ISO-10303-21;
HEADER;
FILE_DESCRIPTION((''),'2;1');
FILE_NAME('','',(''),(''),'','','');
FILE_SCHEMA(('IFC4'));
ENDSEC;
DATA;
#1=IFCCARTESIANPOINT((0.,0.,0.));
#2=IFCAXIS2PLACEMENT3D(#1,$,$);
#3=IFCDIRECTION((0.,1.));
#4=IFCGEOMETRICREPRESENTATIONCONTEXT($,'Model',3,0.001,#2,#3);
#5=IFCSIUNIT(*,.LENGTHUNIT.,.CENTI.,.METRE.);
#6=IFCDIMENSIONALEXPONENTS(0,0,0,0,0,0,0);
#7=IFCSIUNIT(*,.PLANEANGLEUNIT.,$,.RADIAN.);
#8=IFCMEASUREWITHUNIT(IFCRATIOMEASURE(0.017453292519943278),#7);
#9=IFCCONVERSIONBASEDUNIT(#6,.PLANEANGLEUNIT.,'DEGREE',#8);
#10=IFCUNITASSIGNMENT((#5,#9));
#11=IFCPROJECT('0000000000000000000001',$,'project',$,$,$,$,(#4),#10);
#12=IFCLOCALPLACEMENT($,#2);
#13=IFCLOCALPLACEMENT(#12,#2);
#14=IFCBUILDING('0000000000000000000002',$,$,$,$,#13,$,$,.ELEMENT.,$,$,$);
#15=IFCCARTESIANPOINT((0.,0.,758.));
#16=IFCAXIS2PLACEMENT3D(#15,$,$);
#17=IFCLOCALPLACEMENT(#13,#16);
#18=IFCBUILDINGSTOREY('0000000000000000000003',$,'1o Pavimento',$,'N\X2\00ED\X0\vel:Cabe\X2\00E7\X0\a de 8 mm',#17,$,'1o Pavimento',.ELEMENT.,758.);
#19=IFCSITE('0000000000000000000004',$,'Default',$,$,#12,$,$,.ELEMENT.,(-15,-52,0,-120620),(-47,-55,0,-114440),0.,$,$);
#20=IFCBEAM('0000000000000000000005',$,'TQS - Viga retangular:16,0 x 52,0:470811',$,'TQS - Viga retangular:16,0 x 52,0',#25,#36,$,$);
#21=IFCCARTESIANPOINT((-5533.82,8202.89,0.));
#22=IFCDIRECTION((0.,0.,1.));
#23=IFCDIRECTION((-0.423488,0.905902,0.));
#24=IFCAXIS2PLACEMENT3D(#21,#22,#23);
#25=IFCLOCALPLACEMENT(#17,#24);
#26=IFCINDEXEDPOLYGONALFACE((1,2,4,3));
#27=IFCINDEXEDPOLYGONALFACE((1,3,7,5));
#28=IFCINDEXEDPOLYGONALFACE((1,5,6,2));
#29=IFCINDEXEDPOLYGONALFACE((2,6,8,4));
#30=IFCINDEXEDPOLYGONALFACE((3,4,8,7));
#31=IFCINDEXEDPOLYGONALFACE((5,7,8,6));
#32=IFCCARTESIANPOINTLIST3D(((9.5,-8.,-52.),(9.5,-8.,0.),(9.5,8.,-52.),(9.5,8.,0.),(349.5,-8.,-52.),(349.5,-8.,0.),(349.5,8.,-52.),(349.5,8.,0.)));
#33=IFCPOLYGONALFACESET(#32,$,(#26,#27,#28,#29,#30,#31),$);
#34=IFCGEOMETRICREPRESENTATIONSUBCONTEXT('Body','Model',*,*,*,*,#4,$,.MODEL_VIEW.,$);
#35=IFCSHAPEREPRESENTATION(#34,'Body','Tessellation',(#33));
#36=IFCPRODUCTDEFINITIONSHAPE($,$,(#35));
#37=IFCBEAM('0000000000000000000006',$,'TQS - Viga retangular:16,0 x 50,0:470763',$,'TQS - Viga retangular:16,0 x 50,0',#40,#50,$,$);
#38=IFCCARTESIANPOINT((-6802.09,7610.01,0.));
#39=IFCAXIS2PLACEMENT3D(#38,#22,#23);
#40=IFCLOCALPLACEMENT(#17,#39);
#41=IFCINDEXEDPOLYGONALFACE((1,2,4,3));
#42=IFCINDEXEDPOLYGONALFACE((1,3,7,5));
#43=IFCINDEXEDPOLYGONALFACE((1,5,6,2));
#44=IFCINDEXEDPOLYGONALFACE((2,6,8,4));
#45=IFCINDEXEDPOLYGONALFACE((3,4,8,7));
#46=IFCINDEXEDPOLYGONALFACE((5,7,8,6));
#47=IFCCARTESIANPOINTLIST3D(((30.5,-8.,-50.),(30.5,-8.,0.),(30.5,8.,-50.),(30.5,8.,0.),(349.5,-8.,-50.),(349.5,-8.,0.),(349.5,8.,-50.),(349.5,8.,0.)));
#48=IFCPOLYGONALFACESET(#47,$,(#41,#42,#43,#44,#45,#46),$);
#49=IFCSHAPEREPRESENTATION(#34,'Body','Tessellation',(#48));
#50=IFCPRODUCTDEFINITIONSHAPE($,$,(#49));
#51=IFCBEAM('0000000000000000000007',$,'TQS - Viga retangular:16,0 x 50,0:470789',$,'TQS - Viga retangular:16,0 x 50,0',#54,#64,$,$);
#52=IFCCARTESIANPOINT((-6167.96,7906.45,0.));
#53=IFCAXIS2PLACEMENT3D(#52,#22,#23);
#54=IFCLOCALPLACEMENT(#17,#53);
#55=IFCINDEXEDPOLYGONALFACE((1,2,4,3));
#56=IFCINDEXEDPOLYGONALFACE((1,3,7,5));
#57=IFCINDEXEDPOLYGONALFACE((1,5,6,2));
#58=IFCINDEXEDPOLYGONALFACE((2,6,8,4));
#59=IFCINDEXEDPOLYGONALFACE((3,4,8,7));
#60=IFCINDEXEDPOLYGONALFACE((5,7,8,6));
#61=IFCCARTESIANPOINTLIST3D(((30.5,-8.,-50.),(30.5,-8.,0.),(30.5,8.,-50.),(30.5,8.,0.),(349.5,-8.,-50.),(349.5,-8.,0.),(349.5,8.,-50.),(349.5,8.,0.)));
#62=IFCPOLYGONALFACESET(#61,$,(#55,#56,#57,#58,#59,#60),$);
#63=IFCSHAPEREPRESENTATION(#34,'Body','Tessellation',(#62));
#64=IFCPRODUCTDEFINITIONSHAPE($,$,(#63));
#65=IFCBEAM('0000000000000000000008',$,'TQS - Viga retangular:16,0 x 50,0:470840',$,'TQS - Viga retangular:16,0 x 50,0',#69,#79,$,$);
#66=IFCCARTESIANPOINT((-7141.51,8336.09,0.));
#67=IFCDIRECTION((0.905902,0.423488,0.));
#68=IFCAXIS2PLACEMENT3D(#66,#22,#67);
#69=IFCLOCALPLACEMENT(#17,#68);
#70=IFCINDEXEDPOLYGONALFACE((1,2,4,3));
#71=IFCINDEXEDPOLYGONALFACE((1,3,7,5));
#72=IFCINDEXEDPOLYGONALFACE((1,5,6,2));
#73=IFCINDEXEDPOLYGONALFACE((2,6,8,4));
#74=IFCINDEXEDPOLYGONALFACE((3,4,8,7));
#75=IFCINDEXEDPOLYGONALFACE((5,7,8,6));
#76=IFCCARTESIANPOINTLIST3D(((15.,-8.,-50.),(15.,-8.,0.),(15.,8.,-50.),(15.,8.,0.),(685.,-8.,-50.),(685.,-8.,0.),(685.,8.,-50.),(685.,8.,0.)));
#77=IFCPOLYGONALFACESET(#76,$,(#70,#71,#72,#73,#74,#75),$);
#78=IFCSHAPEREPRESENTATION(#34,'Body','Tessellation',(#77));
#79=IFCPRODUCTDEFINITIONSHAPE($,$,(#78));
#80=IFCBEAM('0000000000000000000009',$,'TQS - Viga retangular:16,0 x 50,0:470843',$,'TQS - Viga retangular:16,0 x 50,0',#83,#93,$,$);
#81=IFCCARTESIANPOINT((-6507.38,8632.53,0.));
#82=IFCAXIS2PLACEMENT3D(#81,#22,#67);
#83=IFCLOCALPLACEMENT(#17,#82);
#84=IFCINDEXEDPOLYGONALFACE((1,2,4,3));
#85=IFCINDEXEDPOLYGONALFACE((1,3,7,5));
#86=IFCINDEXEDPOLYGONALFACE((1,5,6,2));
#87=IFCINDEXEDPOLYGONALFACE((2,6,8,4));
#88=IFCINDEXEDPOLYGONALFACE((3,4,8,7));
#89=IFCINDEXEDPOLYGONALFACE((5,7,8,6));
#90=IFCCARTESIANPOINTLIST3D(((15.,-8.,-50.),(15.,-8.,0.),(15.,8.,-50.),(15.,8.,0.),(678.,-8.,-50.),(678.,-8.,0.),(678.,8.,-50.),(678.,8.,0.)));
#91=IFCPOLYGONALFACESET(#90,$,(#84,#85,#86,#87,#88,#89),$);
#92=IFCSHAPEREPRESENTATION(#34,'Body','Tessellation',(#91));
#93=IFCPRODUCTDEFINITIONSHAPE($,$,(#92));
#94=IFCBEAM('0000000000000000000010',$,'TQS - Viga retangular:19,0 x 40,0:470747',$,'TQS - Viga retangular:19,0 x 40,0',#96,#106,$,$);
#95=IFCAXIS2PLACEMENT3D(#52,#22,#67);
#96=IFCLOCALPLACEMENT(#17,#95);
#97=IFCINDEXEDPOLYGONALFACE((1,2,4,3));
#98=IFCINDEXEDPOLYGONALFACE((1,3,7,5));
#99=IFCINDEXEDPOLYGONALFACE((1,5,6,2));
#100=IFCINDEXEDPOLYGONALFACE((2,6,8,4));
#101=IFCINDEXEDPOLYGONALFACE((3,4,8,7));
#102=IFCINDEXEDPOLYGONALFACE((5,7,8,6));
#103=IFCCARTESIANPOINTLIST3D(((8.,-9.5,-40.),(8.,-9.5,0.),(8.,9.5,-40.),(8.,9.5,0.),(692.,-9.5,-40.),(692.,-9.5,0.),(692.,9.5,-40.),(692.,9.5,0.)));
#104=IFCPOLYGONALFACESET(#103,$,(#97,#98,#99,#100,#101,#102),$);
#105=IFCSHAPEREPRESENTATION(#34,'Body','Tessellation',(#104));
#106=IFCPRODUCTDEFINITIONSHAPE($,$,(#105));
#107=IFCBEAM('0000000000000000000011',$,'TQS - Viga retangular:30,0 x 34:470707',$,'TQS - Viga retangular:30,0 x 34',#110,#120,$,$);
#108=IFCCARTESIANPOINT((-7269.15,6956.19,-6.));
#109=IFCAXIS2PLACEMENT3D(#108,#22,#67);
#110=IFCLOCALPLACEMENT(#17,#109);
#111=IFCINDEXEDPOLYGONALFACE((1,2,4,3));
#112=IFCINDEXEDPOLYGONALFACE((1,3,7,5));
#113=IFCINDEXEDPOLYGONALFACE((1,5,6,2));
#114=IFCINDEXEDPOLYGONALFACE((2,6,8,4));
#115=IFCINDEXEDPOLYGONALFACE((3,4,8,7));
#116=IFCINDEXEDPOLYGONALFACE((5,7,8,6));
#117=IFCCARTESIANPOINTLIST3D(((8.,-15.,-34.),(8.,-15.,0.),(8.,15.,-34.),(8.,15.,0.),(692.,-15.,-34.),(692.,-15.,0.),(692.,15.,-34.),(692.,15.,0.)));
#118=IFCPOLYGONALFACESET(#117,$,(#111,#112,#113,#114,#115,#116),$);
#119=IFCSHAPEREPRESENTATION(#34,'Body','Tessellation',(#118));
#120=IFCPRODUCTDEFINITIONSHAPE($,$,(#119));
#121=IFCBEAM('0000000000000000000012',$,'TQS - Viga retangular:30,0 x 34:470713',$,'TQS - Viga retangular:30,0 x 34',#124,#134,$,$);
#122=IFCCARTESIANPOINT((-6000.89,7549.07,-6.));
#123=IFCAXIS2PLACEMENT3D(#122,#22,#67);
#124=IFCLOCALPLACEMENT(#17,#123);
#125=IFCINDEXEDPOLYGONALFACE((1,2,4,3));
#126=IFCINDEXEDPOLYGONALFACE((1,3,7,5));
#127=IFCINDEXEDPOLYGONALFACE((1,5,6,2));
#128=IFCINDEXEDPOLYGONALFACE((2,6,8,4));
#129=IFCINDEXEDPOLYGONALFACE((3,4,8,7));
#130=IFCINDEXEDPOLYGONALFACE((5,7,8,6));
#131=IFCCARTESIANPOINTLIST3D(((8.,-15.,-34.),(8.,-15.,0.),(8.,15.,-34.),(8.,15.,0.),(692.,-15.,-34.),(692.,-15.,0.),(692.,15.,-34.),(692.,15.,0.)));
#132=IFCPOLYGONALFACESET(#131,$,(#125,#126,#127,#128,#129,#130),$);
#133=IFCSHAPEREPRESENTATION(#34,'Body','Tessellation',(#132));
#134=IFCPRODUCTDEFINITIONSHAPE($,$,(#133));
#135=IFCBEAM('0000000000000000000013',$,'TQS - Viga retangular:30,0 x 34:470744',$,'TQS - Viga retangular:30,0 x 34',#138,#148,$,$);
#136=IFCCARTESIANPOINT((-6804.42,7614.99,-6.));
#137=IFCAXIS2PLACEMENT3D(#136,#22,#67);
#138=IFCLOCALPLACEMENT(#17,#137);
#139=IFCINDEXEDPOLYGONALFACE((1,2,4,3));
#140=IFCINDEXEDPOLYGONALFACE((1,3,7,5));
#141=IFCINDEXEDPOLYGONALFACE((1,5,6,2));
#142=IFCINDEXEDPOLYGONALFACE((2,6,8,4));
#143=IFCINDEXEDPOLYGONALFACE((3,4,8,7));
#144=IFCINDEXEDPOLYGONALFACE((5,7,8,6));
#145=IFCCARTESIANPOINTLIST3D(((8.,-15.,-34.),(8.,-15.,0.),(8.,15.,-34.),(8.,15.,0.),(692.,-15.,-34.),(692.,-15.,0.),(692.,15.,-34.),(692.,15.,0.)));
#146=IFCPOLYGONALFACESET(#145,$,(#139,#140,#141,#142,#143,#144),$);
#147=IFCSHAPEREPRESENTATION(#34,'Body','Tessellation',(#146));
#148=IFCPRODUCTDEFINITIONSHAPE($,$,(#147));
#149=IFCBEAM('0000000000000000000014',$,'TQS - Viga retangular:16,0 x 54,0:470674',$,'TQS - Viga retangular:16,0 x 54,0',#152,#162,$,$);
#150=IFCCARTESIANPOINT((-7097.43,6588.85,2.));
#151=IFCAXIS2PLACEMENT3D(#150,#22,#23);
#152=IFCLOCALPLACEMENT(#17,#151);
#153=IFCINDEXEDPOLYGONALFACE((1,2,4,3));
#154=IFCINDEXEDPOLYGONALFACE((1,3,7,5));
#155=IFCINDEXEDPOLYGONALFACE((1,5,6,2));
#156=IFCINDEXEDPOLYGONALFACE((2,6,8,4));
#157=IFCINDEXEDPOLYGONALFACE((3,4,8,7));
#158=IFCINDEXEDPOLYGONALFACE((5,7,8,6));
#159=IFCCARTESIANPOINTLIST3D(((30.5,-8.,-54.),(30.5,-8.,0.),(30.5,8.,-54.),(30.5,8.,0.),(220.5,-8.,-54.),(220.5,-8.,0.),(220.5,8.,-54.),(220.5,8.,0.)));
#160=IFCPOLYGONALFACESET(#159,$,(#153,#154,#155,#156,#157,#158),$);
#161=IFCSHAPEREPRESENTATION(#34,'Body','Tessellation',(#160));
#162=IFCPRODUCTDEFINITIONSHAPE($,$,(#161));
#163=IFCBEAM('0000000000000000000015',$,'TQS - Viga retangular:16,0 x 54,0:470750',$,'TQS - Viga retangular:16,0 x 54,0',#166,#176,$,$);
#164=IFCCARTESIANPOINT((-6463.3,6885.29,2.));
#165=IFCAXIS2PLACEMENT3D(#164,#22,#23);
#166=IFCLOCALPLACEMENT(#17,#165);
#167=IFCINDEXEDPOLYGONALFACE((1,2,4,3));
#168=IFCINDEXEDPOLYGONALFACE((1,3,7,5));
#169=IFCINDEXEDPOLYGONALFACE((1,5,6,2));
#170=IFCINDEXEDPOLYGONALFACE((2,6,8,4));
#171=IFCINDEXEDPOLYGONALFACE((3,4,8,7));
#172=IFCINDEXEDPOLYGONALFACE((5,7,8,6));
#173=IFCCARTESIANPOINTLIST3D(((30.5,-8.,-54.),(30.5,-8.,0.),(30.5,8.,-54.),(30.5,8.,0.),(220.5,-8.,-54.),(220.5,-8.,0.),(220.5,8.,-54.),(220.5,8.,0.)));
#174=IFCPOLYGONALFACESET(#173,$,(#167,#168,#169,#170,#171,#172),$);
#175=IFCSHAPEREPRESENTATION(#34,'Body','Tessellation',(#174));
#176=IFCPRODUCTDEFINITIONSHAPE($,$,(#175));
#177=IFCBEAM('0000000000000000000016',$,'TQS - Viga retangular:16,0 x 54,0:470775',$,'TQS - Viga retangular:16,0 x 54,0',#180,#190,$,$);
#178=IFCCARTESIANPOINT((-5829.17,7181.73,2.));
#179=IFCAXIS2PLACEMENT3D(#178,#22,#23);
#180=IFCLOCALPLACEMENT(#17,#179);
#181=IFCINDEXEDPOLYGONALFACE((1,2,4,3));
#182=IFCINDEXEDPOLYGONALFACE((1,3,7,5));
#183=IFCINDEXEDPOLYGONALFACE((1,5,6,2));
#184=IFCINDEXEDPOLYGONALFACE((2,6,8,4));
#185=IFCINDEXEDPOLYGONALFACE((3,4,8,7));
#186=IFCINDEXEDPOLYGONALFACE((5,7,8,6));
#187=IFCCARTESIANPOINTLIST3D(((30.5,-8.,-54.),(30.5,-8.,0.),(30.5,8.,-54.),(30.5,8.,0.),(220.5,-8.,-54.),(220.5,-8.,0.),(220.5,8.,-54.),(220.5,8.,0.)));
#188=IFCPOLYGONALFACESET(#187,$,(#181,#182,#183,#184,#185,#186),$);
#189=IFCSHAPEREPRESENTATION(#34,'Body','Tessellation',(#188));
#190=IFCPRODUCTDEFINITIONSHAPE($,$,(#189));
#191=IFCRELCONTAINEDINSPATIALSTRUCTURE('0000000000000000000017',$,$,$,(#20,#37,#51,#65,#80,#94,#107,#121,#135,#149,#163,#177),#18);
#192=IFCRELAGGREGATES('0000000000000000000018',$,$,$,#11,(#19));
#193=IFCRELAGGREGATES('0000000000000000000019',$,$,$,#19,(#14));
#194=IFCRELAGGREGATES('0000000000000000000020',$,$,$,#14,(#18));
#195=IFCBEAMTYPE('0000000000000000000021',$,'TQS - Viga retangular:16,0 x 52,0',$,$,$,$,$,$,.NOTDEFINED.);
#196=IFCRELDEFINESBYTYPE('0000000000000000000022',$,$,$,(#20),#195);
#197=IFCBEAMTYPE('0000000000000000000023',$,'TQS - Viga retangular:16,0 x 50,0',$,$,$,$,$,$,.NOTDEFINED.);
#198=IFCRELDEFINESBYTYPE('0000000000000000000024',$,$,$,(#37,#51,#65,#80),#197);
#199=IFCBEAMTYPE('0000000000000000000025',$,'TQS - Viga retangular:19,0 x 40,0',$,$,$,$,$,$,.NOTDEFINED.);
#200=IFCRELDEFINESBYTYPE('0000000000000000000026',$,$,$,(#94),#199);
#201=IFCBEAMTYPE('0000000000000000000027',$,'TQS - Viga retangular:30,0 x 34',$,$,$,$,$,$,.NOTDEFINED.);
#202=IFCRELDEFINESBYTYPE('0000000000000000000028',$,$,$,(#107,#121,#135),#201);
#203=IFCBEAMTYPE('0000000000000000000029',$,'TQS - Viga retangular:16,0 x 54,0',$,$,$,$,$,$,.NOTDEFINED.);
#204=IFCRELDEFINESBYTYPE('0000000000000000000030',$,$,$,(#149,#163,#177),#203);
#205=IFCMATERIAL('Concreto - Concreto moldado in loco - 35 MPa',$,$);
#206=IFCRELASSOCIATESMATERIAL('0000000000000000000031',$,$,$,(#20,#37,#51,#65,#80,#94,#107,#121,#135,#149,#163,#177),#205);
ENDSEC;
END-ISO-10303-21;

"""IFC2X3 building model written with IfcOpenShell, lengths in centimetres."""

from ifc_helpers import new_model, entity, si_unit, converted_unit, direction, frame, frame_2d, origin, origin_2d_with_axis, place, context, subcontext, project, spatial, rectangle, extrude, material, type_object, element, save


model = new_model("IFC2X3")

# Units and contexts
model_context = context("Model", 3, precision=0.001, world=origin(), true_north=direction((0.0, 1.0)))
body_context = subcontext(model_context, "Body", "Model", "MODEL_VIEW")
ifc_project = project(units=[si_unit("LENGTHUNIT", "METRE", prefix="CENTI"), converted_unit("PLANEANGLEUNIT", "DEGREE", entity("IfcRatioMeasure", 0.017453292519943278), si_unit("PLANEANGLEUNIT", "RADIAN"), dimensions=[0, 0, 0, 0, 0, 0, 0])], contexts=[model_context])

# Site, building, storey
site_placement = place(None, origin())
site = spatial("IfcSite", under=ifc_project, at=site_placement, Name="Default", CompositionType="ELEMENT", RefLatitude=(-15, -52, 0, -120620), RefLongitude=(-47, -55, 0, -114440), RefElevation=0.0)
building_placement = place(site_placement, origin())
building = spatial("IfcBuilding", under=site, at=building_placement, CompositionType="ELEMENT")
storey_placement = place(building_placement, frame((0.0, 0.0, 758.0)))
storey = spatial("IfcBuildingStorey", under=building, at=storey_placement, Name="1o Pavimento", ObjectType="Nível:Cabeça de 8 mm", LongName="1o Pavimento", CompositionType="ELEMENT", Elevation=758.0)

# Beams
ifc_material_1 = material(Name="Concreto - Concreto moldado in loco - 35 MPa")
beam_type_1 = type_object("IfcBeamType", Name="TQS - Viga retangular:16,0 x 52,0", PredefinedType="NOTDEFINED")
beam_1_placement = place(storey_placement, frame((-5533.82, 8202.89, 0.0), z_axis=(0.0, 0.0, 1.0), x_axis=(-0.423488, 0.905902, 0.0)))
element("IfcBeam", 1, at=beam_1_placement, inside=storey, type_object=beam_type_1, material=ifc_material_1, Name="TQS - Viga retangular:16,0 x 52,0:470811", ObjectType="TQS - Viga retangular:16,0 x 52,0", context=body_context, shape_type="SweptSolid", body=[
    extrude(rectangle(XDim=52.0, YDim=16.0, at=frame_2d((0.0, 0.0), x_axis=(1.0, 0.0))), frame((9.5, 0.0, -26.0), z_axis=(1.0, 0.0, 0.0), x_axis=(0.0, 0.0, -1.0)), (0.0, 0.0, 1.0), 340.0),
])
beam_type_2 = type_object("IfcBeamType", Name="TQS - Viga retangular:16,0 x 50,0", PredefinedType="NOTDEFINED")
beam_2_placement = place(storey_placement, frame((-6802.09, 7610.01, 0.0), z_axis=(0.0, 0.0, 1.0), x_axis=(-0.423488, 0.905902, 0.0)))
element("IfcBeam", 2, at=beam_2_placement, inside=storey, type_object=beam_type_2, material=ifc_material_1, Name="TQS - Viga retangular:16,0 x 50,0:470763", ObjectType="TQS - Viga retangular:16,0 x 50,0", context=body_context, shape_type="SweptSolid", body=[
    extrude(rectangle(XDim=50.0, YDim=16.0, at=frame_2d((0.0, 0.0), x_axis=(1.0, 0.0))), frame((30.5, 0.0, -25.0), z_axis=(1.0, 0.0, 0.0), x_axis=(0.0, 0.0, -1.0)), (0.0, 0.0, 1.0), 319.0),
])
beam_3_placement = place(storey_placement, frame((-6167.96, 7906.45, 0.0), z_axis=(0.0, 0.0, 1.0), x_axis=(-0.423488, 0.905902, 0.0)))
element("IfcBeam", 3, at=beam_3_placement, inside=storey, type_object=beam_type_2, material=ifc_material_1, Name="TQS - Viga retangular:16,0 x 50,0:470789", ObjectType="TQS - Viga retangular:16,0 x 50,0", context=body_context, shape_type="SweptSolid", body=[
    extrude(rectangle(XDim=50.0, YDim=16.0, at=frame_2d((0.0, 0.0), x_axis=(1.0, 0.0))), frame((30.5, 0.0, -25.0), z_axis=(1.0, 0.0, 0.0), x_axis=(0.0, 0.0, -1.0)), (0.0, 0.0, 1.0), 319.0),
])
beam_4_placement = place(storey_placement, frame((-7141.51, 8336.09, 0.0), z_axis=(0.0, 0.0, 1.0), x_axis=(0.905902, 0.423488, 0.0)))
element("IfcBeam", 4, at=beam_4_placement, inside=storey, type_object=beam_type_2, material=ifc_material_1, Name="TQS - Viga retangular:16,0 x 50,0:470840", ObjectType="TQS - Viga retangular:16,0 x 50,0", context=body_context, shape_type="SweptSolid", body=[
    extrude(rectangle(XDim=50.0, YDim=16.0, at=frame_2d((0.0, 0.0), x_axis=(1.0, 0.0))), frame((15.0, 0.0, -25.0), z_axis=(1.0, 0.0, 0.0), x_axis=(0.0, 0.0, -1.0)), (0.0, 0.0, 1.0), 670.0),
])
beam_5_placement = place(storey_placement, frame((-6507.38, 8632.53, 0.0), z_axis=(0.0, 0.0, 1.0), x_axis=(0.905902, 0.423488, 0.0)))
element("IfcBeam", 5, at=beam_5_placement, inside=storey, type_object=beam_type_2, material=ifc_material_1, Name="TQS - Viga retangular:16,0 x 50,0:470843", ObjectType="TQS - Viga retangular:16,0 x 50,0", context=body_context, shape_type="SweptSolid", body=[
    extrude(rectangle(XDim=50.0, YDim=16.0, at=frame_2d((0.0, 0.0), x_axis=(1.0, 0.0))), frame((15.0, 0.0, -25.0), z_axis=(1.0, 0.0, 0.0), x_axis=(0.0, 0.0, -1.0)), (0.0, 0.0, 1.0), 663.0),
])
beam_type_3 = type_object("IfcBeamType", Name="TQS - Viga retangular:19,0 x 40,0", PredefinedType="NOTDEFINED")
beam_6_placement = place(storey_placement, frame((-6167.96, 7906.45, 0.0), z_axis=(0.0, 0.0, 1.0), x_axis=(0.905902, 0.423488, 0.0)))
element("IfcBeam", 6, at=beam_6_placement, inside=storey, type_object=beam_type_3, material=ifc_material_1, Name="TQS - Viga retangular:19,0 x 40,0:470747", ObjectType="TQS - Viga retangular:19,0 x 40,0", context=body_context, shape_type="SweptSolid", body=[
    extrude(rectangle(XDim=40.0, YDim=19.0, at=frame_2d((0.0, 0.0), x_axis=(1.0, 0.0))), frame((8.0, 0.0, -20.0), z_axis=(1.0, 0.0, 0.0), x_axis=(0.0, 0.0, -1.0)), (0.0, 0.0, 1.0), 684.0),
])
beam_type_4 = type_object("IfcBeamType", Name="TQS - Viga retangular:30,0 x 34", PredefinedType="NOTDEFINED")
beam_7_placement = place(storey_placement, frame((-7269.15, 6956.19, -6.0), z_axis=(0.0, 0.0, 1.0), x_axis=(0.905902, 0.423488, 0.0)))
element("IfcBeam", 7, at=beam_7_placement, inside=storey, type_object=beam_type_4, material=ifc_material_1, Name="TQS - Viga retangular:30,0 x 34:470707", ObjectType="TQS - Viga retangular:30,0 x 34", context=body_context, shape_type="SweptSolid", body=[
    extrude(rectangle(XDim=34.0, YDim=30.0, at=origin_2d_with_axis()), frame((8.0, 0.0, -17.0), z_axis=(1.0, 0.0, 0.0), x_axis=(0.0, 0.0, -1.0)), (0.0, 0.0, 1.0), 684.0),
])
beam_8_placement = place(storey_placement, frame((-6000.89, 7549.07, -6.0), z_axis=(0.0, 0.0, 1.0), x_axis=(0.905902, 0.423488, 0.0)))
element("IfcBeam", 8, at=beam_8_placement, inside=storey, type_object=beam_type_4, material=ifc_material_1, Name="TQS - Viga retangular:30,0 x 34:470713", ObjectType="TQS - Viga retangular:30,0 x 34", context=body_context, shape_type="SweptSolid", body=[
    extrude(rectangle(XDim=34.0, YDim=30.0, at=origin_2d_with_axis()), frame((8.0, 0.0, -17.0), z_axis=(1.0, 0.0, 0.0), x_axis=(0.0, 0.0, -1.0)), (0.0, 0.0, 1.0), 684.0),
])
beam_9_placement = place(storey_placement, frame((-6804.42, 7614.99, -6.0), z_axis=(0.0, 0.0, 1.0), x_axis=(0.905902, 0.423488, 0.0)))
element("IfcBeam", 9, at=beam_9_placement, inside=storey, type_object=beam_type_4, material=ifc_material_1, Name="TQS - Viga retangular:30,0 x 34:470744", ObjectType="TQS - Viga retangular:30,0 x 34", context=body_context, shape_type="SweptSolid", body=[
    extrude(rectangle(XDim=34.0, YDim=30.0, at=frame_2d((0.0, 0.0), x_axis=(1.0, 0.0))), frame((8.0, 0.0, -17.0), z_axis=(1.0, 0.0, 0.0), x_axis=(0.0, 0.0, -1.0)), (0.0, 0.0, 1.0), 684.0),
])
beam_type_5 = type_object("IfcBeamType", Name="TQS - Viga retangular:16,0 x 54,0", PredefinedType="NOTDEFINED")
beam_10_placement = place(storey_placement, frame((-7097.43, 6588.85, 2.0), z_axis=(0.0, 0.0, 1.0), x_axis=(-0.423488, 0.905902, 0.0)))
element("IfcBeam", 10, at=beam_10_placement, inside=storey, type_object=beam_type_5, material=ifc_material_1, Name="TQS - Viga retangular:16,0 x 54,0:470674", ObjectType="TQS - Viga retangular:16,0 x 54,0", context=body_context, shape_type="SweptSolid", body=[
    extrude(rectangle(XDim=54.0, YDim=16.0, at=frame_2d((0.0, 0.0), x_axis=(1.0, 0.0))), frame((30.5, 0.0, -27.0), z_axis=(1.0, 0.0, 0.0), x_axis=(0.0, 0.0, -1.0)), (0.0, 0.0, 1.0), 190.0),
])
beam_11_placement = place(storey_placement, frame((-6463.3, 6885.29, 2.0), z_axis=(0.0, 0.0, 1.0), x_axis=(-0.423488, 0.905902, 0.0)))
element("IfcBeam", 11, at=beam_11_placement, inside=storey, type_object=beam_type_5, material=ifc_material_1, Name="TQS - Viga retangular:16,0 x 54,0:470750", ObjectType="TQS - Viga retangular:16,0 x 54,0", context=body_context, shape_type="SweptSolid", body=[
    extrude(rectangle(XDim=54.0, YDim=16.0, at=origin_2d_with_axis()), frame((30.5, 0.0, -27.0), z_axis=(1.0, 0.0, 0.0), x_axis=(0.0, 0.0, -1.0)), (0.0, 0.0, 1.0), 190.0),
])
beam_12_placement = place(storey_placement, frame((-5829.17, 7181.73, 2.0), z_axis=(0.0, 0.0, 1.0), x_axis=(-0.423488, 0.905902, 0.0)))
element("IfcBeam", 12, at=beam_12_placement, inside=storey, type_object=beam_type_5, material=ifc_material_1, Name="TQS - Viga retangular:16,0 x 54,0:470775", ObjectType="TQS - Viga retangular:16,0 x 54,0", context=body_context, shape_type="SweptSolid", body=[
    extrude(rectangle(XDim=54.0, YDim=16.0, at=frame_2d((0.0, 0.0), x_axis=(1.0, 0.0))), frame((30.5, 0.0, -27.0), z_axis=(1.0, 0.0, 0.0), x_axis=(0.0, 0.0, -1.0)), (0.0, 0.0, 1.0), 190.0),
])

save(model, "model.ifc")
